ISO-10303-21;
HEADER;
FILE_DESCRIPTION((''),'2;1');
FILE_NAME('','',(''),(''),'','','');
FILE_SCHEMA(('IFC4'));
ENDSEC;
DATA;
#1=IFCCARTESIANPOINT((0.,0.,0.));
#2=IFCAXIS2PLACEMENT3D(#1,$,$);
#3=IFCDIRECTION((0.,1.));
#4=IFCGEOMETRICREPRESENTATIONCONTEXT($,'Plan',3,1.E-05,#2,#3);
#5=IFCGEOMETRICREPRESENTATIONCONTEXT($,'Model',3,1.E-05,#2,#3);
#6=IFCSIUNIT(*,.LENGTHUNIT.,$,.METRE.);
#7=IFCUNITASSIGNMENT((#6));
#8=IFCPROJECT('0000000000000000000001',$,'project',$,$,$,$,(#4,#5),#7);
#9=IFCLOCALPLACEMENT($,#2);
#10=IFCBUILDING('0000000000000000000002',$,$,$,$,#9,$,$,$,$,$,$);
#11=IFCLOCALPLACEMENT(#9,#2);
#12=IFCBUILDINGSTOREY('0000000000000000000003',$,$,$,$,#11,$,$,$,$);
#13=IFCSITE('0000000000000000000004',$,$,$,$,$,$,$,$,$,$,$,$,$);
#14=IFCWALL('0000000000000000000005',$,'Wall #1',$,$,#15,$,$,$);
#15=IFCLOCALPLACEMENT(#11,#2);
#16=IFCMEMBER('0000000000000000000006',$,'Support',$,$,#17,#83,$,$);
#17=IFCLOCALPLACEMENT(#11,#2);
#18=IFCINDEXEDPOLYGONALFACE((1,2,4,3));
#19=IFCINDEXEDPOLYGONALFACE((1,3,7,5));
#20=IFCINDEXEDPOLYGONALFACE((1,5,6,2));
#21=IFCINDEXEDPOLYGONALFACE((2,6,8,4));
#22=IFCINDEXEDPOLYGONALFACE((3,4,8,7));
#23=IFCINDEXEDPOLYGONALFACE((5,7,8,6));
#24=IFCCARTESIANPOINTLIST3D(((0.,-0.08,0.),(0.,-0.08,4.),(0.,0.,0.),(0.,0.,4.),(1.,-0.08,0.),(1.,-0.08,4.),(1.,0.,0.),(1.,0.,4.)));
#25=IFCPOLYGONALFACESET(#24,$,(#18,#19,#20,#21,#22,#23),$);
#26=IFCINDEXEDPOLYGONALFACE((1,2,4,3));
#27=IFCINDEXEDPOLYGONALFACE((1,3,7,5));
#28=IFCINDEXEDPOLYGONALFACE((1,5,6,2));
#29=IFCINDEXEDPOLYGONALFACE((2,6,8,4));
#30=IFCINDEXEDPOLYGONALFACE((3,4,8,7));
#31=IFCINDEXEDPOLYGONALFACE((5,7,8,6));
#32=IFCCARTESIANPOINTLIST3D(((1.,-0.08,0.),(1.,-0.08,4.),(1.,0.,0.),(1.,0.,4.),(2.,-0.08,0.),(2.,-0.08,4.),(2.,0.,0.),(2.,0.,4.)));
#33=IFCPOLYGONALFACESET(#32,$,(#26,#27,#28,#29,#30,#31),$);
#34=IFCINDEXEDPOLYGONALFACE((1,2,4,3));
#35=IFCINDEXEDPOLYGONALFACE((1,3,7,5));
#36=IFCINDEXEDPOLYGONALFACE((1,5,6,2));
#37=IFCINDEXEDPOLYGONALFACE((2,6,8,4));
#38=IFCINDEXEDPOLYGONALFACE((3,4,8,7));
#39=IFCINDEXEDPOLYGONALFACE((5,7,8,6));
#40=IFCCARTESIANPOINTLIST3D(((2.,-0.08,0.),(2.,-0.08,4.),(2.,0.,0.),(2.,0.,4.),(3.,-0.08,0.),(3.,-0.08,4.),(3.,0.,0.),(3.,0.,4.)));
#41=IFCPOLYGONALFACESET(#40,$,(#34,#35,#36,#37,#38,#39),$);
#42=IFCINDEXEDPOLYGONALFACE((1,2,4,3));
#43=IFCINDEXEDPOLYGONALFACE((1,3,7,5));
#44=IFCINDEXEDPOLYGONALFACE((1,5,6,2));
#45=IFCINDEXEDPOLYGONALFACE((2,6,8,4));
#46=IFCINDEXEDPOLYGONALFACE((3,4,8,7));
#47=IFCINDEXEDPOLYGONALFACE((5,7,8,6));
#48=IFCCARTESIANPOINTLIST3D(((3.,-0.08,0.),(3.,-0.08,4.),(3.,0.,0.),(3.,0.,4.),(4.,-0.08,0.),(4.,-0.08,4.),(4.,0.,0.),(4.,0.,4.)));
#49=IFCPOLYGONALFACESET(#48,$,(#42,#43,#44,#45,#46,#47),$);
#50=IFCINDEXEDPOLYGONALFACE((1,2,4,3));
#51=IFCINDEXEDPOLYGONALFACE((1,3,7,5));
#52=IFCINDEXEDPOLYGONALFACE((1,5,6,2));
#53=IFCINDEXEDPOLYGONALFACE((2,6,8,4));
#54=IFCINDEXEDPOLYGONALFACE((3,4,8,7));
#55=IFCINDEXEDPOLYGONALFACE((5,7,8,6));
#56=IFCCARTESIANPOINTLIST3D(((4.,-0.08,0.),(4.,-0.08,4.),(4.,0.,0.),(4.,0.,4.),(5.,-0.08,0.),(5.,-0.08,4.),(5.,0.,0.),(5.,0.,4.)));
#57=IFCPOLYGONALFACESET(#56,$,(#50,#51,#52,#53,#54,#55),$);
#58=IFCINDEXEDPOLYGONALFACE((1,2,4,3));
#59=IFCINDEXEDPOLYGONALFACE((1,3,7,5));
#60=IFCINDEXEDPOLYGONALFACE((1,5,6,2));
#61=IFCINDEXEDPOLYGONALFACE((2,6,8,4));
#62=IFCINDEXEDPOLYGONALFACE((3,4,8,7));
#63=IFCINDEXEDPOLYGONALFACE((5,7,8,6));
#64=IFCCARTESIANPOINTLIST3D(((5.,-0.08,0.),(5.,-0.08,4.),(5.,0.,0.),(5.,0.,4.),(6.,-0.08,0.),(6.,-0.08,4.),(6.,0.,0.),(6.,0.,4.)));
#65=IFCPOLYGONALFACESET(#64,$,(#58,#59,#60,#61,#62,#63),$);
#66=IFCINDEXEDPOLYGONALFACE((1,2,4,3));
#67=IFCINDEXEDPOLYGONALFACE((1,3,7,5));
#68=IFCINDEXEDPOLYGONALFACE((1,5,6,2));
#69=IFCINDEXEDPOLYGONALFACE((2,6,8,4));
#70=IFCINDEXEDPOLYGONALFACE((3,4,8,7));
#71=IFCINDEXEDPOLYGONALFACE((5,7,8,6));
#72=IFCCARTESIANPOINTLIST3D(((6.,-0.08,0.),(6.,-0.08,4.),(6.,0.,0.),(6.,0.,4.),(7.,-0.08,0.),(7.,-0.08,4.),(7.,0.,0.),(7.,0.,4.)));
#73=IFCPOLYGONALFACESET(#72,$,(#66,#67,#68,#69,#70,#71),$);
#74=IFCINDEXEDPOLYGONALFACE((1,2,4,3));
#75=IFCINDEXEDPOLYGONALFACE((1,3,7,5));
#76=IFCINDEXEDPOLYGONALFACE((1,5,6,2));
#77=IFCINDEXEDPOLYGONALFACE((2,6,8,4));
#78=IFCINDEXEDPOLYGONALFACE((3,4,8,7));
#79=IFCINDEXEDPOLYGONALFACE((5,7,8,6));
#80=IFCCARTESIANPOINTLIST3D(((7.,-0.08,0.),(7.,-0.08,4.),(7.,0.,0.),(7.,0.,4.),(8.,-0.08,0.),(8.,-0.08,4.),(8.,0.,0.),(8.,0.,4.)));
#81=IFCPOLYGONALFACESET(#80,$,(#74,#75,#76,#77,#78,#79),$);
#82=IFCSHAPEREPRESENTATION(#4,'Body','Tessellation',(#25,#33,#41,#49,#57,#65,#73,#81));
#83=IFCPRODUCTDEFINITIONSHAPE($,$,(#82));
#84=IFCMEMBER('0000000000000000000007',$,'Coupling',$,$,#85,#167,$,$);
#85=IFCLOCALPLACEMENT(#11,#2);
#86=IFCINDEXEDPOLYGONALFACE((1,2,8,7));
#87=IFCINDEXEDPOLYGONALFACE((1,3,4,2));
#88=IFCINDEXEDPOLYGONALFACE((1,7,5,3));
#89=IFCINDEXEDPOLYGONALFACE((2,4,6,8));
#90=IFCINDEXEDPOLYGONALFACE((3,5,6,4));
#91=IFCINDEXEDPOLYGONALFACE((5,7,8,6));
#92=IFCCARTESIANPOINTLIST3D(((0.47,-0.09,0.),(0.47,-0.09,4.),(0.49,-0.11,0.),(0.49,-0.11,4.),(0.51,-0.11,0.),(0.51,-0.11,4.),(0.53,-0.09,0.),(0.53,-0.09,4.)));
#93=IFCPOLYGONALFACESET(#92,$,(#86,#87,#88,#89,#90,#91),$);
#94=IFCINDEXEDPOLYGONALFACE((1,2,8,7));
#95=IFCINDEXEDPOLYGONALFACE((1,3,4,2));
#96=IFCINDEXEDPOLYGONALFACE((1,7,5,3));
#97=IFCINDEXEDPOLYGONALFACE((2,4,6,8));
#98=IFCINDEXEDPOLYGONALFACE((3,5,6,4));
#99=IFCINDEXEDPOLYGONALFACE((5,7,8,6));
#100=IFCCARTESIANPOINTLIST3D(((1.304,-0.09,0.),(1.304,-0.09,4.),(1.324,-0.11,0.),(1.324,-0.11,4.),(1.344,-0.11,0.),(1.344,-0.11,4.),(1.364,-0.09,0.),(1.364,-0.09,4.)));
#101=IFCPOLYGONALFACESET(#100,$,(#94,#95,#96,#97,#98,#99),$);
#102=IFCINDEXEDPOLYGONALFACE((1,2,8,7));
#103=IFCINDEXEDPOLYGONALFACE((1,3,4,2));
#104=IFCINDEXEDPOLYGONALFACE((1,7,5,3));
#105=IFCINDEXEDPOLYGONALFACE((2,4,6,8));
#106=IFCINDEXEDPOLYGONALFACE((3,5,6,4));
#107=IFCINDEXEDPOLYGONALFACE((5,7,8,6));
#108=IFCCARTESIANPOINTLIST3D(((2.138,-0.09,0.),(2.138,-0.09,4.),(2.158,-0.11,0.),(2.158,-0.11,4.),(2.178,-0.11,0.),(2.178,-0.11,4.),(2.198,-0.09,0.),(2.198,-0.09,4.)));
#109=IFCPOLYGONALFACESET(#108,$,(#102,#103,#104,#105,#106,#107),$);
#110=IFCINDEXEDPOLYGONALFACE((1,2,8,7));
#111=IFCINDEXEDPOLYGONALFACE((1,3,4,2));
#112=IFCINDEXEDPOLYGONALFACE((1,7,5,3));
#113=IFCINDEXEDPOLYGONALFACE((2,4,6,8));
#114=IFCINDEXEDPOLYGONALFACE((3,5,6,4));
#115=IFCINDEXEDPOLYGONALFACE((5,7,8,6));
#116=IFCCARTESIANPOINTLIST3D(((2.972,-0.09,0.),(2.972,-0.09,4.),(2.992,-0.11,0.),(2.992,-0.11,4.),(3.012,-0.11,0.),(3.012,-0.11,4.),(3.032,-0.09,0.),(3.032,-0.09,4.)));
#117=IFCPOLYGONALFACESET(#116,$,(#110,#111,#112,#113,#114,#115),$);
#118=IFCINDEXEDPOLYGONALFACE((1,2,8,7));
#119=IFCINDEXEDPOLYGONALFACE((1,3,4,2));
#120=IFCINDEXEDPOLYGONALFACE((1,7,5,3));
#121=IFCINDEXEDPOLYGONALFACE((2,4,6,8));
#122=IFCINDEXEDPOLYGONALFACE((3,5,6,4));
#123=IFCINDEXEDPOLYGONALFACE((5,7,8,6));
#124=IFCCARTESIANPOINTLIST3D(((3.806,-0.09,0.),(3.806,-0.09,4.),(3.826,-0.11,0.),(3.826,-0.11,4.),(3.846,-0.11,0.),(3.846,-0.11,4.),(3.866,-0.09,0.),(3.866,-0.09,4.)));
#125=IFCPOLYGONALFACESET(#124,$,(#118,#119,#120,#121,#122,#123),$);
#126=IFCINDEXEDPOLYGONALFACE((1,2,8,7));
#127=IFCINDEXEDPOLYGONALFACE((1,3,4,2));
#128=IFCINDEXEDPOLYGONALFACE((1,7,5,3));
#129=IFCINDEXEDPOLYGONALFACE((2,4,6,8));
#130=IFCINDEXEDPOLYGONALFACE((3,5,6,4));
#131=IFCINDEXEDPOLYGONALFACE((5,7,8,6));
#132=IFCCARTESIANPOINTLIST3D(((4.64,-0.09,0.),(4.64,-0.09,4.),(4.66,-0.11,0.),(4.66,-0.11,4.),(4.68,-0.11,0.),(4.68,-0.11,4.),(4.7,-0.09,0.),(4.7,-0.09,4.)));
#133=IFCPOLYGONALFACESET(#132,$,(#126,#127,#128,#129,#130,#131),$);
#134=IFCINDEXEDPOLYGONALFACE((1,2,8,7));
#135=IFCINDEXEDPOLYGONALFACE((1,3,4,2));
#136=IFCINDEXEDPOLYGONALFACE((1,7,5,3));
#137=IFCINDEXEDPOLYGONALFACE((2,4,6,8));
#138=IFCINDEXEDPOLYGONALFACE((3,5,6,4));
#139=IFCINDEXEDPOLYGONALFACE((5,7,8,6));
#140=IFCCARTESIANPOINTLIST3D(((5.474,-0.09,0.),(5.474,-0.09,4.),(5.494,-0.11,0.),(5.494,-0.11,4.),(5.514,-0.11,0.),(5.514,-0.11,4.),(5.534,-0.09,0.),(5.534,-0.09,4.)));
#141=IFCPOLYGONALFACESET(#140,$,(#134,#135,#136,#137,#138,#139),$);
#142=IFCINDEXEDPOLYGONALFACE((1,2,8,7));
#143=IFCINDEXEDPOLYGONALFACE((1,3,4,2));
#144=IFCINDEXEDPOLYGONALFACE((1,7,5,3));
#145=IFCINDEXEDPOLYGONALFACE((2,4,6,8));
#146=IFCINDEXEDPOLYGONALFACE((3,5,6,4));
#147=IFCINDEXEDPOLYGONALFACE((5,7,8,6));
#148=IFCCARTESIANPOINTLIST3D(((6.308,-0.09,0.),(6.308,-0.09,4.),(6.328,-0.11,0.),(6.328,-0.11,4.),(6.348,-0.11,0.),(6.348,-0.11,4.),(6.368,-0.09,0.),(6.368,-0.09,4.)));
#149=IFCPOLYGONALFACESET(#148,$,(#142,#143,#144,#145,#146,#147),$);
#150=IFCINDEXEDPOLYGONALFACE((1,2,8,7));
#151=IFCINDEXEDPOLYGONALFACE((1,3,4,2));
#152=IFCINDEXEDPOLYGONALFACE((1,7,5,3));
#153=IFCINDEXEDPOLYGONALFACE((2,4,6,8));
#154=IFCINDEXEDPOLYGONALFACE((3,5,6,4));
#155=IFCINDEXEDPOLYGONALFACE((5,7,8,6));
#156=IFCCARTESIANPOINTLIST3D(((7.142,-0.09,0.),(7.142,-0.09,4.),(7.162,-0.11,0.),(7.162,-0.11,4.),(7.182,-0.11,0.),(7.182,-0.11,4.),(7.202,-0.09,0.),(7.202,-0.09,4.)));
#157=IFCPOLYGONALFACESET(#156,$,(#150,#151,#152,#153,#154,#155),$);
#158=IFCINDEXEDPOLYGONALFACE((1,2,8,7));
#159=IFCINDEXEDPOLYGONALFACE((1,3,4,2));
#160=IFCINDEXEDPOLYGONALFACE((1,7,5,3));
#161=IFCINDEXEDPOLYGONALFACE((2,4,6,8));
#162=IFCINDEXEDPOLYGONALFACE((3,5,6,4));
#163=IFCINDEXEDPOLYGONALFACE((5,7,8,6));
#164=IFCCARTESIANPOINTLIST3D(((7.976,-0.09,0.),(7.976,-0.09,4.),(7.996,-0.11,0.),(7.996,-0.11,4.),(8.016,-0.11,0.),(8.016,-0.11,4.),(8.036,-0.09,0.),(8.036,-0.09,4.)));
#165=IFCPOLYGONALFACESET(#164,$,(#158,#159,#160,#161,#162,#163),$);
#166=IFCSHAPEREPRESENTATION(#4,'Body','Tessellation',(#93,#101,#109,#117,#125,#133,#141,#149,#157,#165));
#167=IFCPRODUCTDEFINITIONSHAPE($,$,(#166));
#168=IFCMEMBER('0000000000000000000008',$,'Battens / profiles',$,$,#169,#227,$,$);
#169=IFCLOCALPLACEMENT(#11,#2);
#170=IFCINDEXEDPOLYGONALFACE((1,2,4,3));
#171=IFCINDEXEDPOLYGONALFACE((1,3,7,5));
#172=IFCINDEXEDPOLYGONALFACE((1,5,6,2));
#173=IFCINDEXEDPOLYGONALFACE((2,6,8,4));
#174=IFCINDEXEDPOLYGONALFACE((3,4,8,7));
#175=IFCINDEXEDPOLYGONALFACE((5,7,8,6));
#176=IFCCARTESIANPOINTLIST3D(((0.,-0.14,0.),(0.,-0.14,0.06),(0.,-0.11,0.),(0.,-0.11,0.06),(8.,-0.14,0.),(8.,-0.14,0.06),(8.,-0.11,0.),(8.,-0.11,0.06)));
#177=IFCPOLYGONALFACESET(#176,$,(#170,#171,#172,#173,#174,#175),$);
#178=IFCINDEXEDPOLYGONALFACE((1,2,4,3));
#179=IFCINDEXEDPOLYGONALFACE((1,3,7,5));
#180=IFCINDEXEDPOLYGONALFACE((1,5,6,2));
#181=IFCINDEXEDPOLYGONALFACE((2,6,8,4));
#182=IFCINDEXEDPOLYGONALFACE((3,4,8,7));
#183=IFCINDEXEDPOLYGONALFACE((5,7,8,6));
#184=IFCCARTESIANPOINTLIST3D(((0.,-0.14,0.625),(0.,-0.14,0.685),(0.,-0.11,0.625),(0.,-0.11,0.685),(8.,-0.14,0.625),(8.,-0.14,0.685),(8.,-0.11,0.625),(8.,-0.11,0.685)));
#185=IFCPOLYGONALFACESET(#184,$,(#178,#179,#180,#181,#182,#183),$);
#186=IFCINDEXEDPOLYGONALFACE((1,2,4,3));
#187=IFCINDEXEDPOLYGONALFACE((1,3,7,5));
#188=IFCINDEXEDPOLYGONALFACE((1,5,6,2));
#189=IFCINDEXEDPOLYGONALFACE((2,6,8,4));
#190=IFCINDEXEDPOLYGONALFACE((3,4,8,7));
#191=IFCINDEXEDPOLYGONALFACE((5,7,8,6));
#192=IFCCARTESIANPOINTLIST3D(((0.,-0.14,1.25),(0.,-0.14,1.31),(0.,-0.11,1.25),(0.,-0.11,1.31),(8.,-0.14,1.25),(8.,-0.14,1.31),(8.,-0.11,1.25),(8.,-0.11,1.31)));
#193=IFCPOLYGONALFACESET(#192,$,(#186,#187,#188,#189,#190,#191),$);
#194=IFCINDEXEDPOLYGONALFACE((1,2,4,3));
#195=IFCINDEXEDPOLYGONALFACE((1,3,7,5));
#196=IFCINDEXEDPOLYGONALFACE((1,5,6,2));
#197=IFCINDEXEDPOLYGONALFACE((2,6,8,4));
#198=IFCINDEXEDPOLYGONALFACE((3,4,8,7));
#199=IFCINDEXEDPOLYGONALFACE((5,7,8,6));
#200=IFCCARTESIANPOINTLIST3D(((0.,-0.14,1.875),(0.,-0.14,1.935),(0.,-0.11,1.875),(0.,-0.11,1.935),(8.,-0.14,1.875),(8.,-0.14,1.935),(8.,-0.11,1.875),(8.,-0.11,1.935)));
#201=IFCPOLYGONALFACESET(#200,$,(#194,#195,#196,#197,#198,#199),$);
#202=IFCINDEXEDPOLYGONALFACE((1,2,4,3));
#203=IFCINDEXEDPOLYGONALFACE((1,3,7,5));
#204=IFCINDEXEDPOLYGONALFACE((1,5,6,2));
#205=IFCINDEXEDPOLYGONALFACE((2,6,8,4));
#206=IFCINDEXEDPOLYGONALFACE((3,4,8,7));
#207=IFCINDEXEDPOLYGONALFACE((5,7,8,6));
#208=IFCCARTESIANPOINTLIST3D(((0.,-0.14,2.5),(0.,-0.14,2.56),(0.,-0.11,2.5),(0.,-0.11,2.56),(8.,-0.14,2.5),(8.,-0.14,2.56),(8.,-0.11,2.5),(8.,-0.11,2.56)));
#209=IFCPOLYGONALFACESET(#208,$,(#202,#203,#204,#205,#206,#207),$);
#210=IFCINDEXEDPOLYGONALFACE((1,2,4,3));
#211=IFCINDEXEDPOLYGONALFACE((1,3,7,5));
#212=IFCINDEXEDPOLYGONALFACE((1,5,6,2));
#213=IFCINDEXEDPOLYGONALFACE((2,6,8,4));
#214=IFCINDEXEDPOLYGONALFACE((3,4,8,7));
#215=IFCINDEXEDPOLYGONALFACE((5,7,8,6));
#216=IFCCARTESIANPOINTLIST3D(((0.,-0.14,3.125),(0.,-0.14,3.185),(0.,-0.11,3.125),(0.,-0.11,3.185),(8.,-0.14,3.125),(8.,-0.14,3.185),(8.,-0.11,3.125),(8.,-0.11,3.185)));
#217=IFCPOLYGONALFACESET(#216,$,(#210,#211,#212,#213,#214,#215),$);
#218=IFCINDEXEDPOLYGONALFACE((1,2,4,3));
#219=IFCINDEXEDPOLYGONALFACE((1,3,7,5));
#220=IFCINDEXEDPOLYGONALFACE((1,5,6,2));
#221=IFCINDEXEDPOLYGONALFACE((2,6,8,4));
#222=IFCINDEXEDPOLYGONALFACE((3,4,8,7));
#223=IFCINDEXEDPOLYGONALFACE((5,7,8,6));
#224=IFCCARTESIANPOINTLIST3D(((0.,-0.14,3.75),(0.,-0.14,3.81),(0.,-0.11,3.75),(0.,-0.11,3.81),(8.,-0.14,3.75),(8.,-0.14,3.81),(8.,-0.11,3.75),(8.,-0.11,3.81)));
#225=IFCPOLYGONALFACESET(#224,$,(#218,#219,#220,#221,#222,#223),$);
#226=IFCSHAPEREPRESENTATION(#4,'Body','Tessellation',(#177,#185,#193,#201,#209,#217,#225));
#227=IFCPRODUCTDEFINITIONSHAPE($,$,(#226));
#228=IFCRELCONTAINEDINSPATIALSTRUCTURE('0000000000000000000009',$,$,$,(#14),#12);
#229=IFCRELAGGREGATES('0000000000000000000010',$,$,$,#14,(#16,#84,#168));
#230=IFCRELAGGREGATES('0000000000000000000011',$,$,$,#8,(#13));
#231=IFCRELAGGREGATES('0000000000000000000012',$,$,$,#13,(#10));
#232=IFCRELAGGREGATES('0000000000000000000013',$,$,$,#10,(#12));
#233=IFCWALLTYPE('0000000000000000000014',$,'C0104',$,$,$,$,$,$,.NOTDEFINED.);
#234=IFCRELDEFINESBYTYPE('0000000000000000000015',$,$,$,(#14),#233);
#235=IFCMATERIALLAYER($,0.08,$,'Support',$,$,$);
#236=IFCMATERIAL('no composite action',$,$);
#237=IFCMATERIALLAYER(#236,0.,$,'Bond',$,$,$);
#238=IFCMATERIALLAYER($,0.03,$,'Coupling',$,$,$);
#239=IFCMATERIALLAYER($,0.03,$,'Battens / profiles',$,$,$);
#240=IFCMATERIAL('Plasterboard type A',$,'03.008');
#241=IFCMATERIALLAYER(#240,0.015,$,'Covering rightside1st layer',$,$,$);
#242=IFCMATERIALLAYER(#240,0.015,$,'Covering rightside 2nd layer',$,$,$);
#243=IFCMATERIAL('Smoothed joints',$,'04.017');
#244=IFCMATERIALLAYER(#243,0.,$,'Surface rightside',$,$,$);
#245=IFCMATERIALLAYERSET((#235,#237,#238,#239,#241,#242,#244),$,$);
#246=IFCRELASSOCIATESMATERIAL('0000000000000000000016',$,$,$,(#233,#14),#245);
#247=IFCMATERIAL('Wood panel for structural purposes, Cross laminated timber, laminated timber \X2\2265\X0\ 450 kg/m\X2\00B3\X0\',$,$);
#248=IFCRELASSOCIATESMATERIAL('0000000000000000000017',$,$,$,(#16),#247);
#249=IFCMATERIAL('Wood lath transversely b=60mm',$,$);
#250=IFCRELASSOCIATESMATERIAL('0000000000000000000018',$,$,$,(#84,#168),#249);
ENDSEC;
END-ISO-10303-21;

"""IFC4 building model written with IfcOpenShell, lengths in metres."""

from ifc_helpers import new_model, si_unit, direction, frame, frame_2d, origin, place, context, project, spatial, polyline, rectangle, outline, extrude, material, layer, layer_set, type_object, element, aggregate, save


model = new_model("IFC4")

# Units and contexts
plan_context = context("Plan", 3, precision=1e-05, world=origin(), true_north=direction((0.0, 1.0)))
model_context = context("Model", 3, precision=1e-05, world=origin(), true_north=direction((0.0, 1.0)))
ifc_project = project(units=[si_unit("LENGTHUNIT", "METRE")], contexts=[plan_context, model_context])

# Site, building, storey
site = spatial("IfcSite", under=ifc_project)
building_placement = place(None, origin())
building = spatial("IfcBuilding", under=site, at=building_placement)
storey_placement = place(building_placement, origin())
storey = spatial("IfcBuildingStorey", under=building, at=storey_placement)

# Wall, members
ifc_layer_1 = layer(None, 0.08, Name="Support")
ifc_material_1 = material(Name="no composite action")
ifc_layer_2 = layer(ifc_material_1, 0.0, Name="Bond")
ifc_layer_3 = layer(None, 0.03, Name="Coupling")
ifc_layer_4 = layer(None, 0.03, Name="Battens / profiles")
ifc_material_2 = material(Name="Plasterboard type A", Category="03.008")
ifc_layer_5 = layer(ifc_material_2, 0.015, Name="Covering rightside1st layer")
ifc_layer_6 = layer(ifc_material_2, 0.015, Name="Covering rightside 2nd layer")
ifc_material_3 = material(Name="Smoothed joints", Category="04.017")
ifc_layer_7 = layer(ifc_material_3, 0.0, Name="Surface rightside")
ifc_layer_set = layer_set([ifc_layer_1, ifc_layer_2, ifc_layer_3, ifc_layer_4, ifc_layer_5, ifc_layer_6, ifc_layer_7])
wall_type = type_object("IfcWallType", Name="C0104", PredefinedType="NOTDEFINED", material=ifc_layer_set)
wall_placement = place(None, frame((0.0, 0.0, 0.0), z_axis=(0.0, -1.0, 0.0), x_axis=(1.0, 0.0, 0.0)))
wall = element("IfcWall", 1, at=wall_placement, inside=storey, type_object=wall_type, material=ifc_layer_set, Name="Wall #1")
ifc_material_4 = material(Name="Wood panel for structural purposes, Cross laminated timber, laminated timber ≥ 450 kg/m³")
member_1_placement = place(wall_placement, origin())
member_1 = element("IfcMember", 2, at=member_1_placement, material=ifc_material_4, Name="Support", context=plan_context, shape_type="SweptSolid", body=[
    extrude(rectangle(XDim=1.0, YDim=0.08, at=frame_2d((0.5, 0.04), x_axis=(1.0, 0.0))), frame((0.0, 4.0, 0.0), z_axis=(0.0, -1.0, 0.0), x_axis=(1.0, 0.0, 0.0)), (0.0, 0.0, 1.0), 4.0),
    extrude(rectangle(XDim=1.0, YDim=0.08, at=frame_2d((0.5, 0.04), x_axis=(1.0, 0.0))), frame((1.0, 4.0, 0.0), z_axis=(0.0, -1.0, 0.0), x_axis=(1.0, 0.0, 0.0)), (0.0, 0.0, 1.0), 4.0),
    extrude(rectangle(XDim=1.0, YDim=0.08, at=frame_2d((0.5, 0.04), x_axis=(1.0, 0.0))), frame((2.0, 4.0, 0.0), z_axis=(0.0, -1.0, 0.0), x_axis=(1.0, 0.0, 0.0)), (0.0, 0.0, 1.0), 4.0),
    extrude(rectangle(XDim=1.0, YDim=0.08, at=frame_2d((0.5, 0.04), x_axis=(1.0, 0.0))), frame((3.0, 4.0, 0.0), z_axis=(0.0, -1.0, 0.0), x_axis=(1.0, 0.0, 0.0)), (0.0, 0.0, 1.0), 4.0),
    extrude(rectangle(XDim=1.0, YDim=0.08, at=frame_2d((0.5, 0.04), x_axis=(1.0, 0.0))), frame((4.0, 4.0, 0.0), z_axis=(0.0, -1.0, 0.0), x_axis=(1.0, 0.0, 0.0)), (0.0, 0.0, 1.0), 4.0),
    extrude(rectangle(XDim=1.0, YDim=0.08, at=frame_2d((0.5, 0.04), x_axis=(1.0, 0.0))), frame((5.0, 4.0, 0.0), z_axis=(0.0, -1.0, 0.0), x_axis=(1.0, 0.0, 0.0)), (0.0, 0.0, 1.0), 4.0),
    extrude(rectangle(XDim=1.0, YDim=0.08, at=frame_2d((0.5, 0.04), x_axis=(1.0, 0.0))), frame((6.0, 4.0, 0.0), z_axis=(0.0, -1.0, 0.0), x_axis=(1.0, 0.0, 0.0)), (0.0, 0.0, 1.0), 4.0),
    extrude(rectangle(XDim=1.0, YDim=0.08, at=frame_2d((0.5, 0.04), x_axis=(1.0, 0.0))), frame((7.0, 4.0, 0.0), z_axis=(0.0, -1.0, 0.0), x_axis=(1.0, 0.0, 0.0)), (0.0, 0.0, 1.0), 4.0),
])
ifc_material_5 = material(Name="Wood lath transversely b=60mm")
member_2_placement = place(wall_placement, origin())
member_2 = element("IfcMember", 3, at=member_2_placement, material=ifc_material_5, Name="Coupling", context=plan_context, shape_type="SweptSolid", body=[
    extrude(outline(polyline([(0.0, 0.0), (0.06, 0.0), (0.04, 0.02), (0.02, 0.02), (0.0, 0.0)])), frame((0.47, 4.0, 0.09), z_axis=(0.0, -1.0, 0.0), x_axis=(1.0, 0.0, 0.0)), (0.0, 0.0, 1.0), 4.0),
    extrude(outline(polyline([(0.0, 0.0), (0.06, 0.0), (0.04, 0.02), (0.02, 0.02), (0.0, 0.0)])), frame((1.304, 4.0, 0.09), z_axis=(0.0, -1.0, 0.0), x_axis=(1.0, 0.0, 0.0)), (0.0, 0.0, 1.0), 4.0),
    extrude(outline(polyline([(0.0, 0.0), (0.06, 0.0), (0.04, 0.02), (0.02, 0.02), (0.0, 0.0)])), frame((2.138, 4.0, 0.09), z_axis=(0.0, -1.0, 0.0), x_axis=(1.0, 0.0, 0.0)), (0.0, 0.0, 1.0), 4.0),
    extrude(outline(polyline([(0.0, 0.0), (0.06, 0.0), (0.04, 0.02), (0.02, 0.02), (0.0, 0.0)])), frame((2.972, 4.0, 0.09), z_axis=(0.0, -1.0, 0.0), x_axis=(1.0, 0.0, 0.0)), (0.0, 0.0, 1.0), 4.0),
    extrude(outline(polyline([(0.0, 0.0), (0.06, 0.0), (0.04, 0.02), (0.02, 0.02), (0.0, 0.0)])), frame((3.806, 4.0, 0.09), z_axis=(0.0, -1.0, 0.0), x_axis=(1.0, 0.0, 0.0)), (0.0, 0.0, 1.0), 4.0),
    extrude(outline(polyline([(0.0, 0.0), (0.06, 0.0), (0.04, 0.02), (0.02, 0.02), (0.0, 0.0)])), frame((4.64, 4.0, 0.09), z_axis=(0.0, -1.0, 0.0), x_axis=(1.0, 0.0, 0.0)), (0.0, 0.0, 1.0), 4.0),
    extrude(outline(polyline([(0.0, 0.0), (0.06, 0.0), (0.04, 0.02), (0.02, 0.02), (0.0, 0.0)])), frame((5.474, 4.0, 0.09), z_axis=(0.0, -1.0, 0.0), x_axis=(1.0, 0.0, 0.0)), (0.0, 0.0, 1.0), 4.0),
    extrude(outline(polyline([(0.0, 0.0), (0.06, 0.0), (0.04, 0.02), (0.02, 0.02), (0.0, 0.0)])), frame((6.308, 4.0, 0.09), z_axis=(0.0, -1.0, 0.0), x_axis=(1.0, 0.0, 0.0)), (0.0, 0.0, 1.0), 4.0),
    extrude(outline(polyline([(0.0, 0.0), (0.06, 0.0), (0.04, 0.02), (0.02, 0.02), (0.0, 0.0)])), frame((7.142, 4.0, 0.09), z_axis=(0.0, -1.0, 0.0), x_axis=(1.0, 0.0, 0.0)), (0.0, 0.0, 1.0), 4.0),
    extrude(outline(polyline([(0.0, 0.0), (0.06, 0.0), (0.04, 0.02), (0.02, 0.02), (0.0, 0.0)])), frame((7.976, 4.0, 0.09), z_axis=(0.0, -1.0, 0.0), x_axis=(1.0, 0.0, 0.0)), (0.0, 0.0, 1.0), 4.0),
])
member_3_placement = place(wall_placement, origin())
member_3 = element("IfcMember", 4, at=member_3_placement, material=ifc_material_5, Name="Battens / profiles", context=plan_context, shape_type="SweptSolid", body=[
    extrude(rectangle(XDim=0.06, YDim=0.03, at=frame_2d((0.03, 0.015), x_axis=(1.0, 0.0))), frame((0.0, 0.0, 0.11), z_axis=(1.0, 0.0, 0.0), x_axis=(0.0, 1.0, 0.0)), (0.0, 0.0, 1.0), 8.0),
    extrude(rectangle(XDim=0.06, YDim=0.03, at=frame_2d((0.03, 0.015), x_axis=(1.0, 0.0))), frame((0.0, 0.625, 0.11), z_axis=(1.0, 0.0, 0.0), x_axis=(0.0, 1.0, 0.0)), (0.0, 0.0, 1.0), 8.0),
    extrude(rectangle(XDim=0.06, YDim=0.03, at=frame_2d((0.03, 0.015), x_axis=(1.0, 0.0))), frame((0.0, 1.25, 0.11), z_axis=(1.0, 0.0, 0.0), x_axis=(0.0, 1.0, 0.0)), (0.0, 0.0, 1.0), 8.0),
    extrude(rectangle(XDim=0.06, YDim=0.03, at=frame_2d((0.03, 0.015), x_axis=(1.0, 0.0))), frame((0.0, 1.875, 0.11), z_axis=(1.0, 0.0, 0.0), x_axis=(0.0, 1.0, 0.0)), (0.0, 0.0, 1.0), 8.0),
    extrude(rectangle(XDim=0.06, YDim=0.03, at=frame_2d((0.03, 0.015), x_axis=(1.0, 0.0))), frame((0.0, 2.5, 0.11), z_axis=(1.0, 0.0, 0.0), x_axis=(0.0, 1.0, 0.0)), (0.0, 0.0, 1.0), 8.0),
    extrude(rectangle(XDim=0.06, YDim=0.03, at=frame_2d((0.03, 0.015), x_axis=(1.0, 0.0))), frame((0.0, 3.125, 0.11), z_axis=(1.0, 0.0, 0.0), x_axis=(0.0, 1.0, 0.0)), (0.0, 0.0, 1.0), 8.0),
    extrude(rectangle(XDim=0.06, YDim=0.03, at=frame_2d((0.03, 0.015), x_axis=(1.0, 0.0))), frame((0.0, 3.75, 0.11), z_axis=(1.0, 0.0, 0.0), x_axis=(0.0, 1.0, 0.0)), (0.0, 0.0, 1.0), 8.0),
])
aggregate(wall, [member_1, member_2, member_3])

save(model, "model.ifc")
